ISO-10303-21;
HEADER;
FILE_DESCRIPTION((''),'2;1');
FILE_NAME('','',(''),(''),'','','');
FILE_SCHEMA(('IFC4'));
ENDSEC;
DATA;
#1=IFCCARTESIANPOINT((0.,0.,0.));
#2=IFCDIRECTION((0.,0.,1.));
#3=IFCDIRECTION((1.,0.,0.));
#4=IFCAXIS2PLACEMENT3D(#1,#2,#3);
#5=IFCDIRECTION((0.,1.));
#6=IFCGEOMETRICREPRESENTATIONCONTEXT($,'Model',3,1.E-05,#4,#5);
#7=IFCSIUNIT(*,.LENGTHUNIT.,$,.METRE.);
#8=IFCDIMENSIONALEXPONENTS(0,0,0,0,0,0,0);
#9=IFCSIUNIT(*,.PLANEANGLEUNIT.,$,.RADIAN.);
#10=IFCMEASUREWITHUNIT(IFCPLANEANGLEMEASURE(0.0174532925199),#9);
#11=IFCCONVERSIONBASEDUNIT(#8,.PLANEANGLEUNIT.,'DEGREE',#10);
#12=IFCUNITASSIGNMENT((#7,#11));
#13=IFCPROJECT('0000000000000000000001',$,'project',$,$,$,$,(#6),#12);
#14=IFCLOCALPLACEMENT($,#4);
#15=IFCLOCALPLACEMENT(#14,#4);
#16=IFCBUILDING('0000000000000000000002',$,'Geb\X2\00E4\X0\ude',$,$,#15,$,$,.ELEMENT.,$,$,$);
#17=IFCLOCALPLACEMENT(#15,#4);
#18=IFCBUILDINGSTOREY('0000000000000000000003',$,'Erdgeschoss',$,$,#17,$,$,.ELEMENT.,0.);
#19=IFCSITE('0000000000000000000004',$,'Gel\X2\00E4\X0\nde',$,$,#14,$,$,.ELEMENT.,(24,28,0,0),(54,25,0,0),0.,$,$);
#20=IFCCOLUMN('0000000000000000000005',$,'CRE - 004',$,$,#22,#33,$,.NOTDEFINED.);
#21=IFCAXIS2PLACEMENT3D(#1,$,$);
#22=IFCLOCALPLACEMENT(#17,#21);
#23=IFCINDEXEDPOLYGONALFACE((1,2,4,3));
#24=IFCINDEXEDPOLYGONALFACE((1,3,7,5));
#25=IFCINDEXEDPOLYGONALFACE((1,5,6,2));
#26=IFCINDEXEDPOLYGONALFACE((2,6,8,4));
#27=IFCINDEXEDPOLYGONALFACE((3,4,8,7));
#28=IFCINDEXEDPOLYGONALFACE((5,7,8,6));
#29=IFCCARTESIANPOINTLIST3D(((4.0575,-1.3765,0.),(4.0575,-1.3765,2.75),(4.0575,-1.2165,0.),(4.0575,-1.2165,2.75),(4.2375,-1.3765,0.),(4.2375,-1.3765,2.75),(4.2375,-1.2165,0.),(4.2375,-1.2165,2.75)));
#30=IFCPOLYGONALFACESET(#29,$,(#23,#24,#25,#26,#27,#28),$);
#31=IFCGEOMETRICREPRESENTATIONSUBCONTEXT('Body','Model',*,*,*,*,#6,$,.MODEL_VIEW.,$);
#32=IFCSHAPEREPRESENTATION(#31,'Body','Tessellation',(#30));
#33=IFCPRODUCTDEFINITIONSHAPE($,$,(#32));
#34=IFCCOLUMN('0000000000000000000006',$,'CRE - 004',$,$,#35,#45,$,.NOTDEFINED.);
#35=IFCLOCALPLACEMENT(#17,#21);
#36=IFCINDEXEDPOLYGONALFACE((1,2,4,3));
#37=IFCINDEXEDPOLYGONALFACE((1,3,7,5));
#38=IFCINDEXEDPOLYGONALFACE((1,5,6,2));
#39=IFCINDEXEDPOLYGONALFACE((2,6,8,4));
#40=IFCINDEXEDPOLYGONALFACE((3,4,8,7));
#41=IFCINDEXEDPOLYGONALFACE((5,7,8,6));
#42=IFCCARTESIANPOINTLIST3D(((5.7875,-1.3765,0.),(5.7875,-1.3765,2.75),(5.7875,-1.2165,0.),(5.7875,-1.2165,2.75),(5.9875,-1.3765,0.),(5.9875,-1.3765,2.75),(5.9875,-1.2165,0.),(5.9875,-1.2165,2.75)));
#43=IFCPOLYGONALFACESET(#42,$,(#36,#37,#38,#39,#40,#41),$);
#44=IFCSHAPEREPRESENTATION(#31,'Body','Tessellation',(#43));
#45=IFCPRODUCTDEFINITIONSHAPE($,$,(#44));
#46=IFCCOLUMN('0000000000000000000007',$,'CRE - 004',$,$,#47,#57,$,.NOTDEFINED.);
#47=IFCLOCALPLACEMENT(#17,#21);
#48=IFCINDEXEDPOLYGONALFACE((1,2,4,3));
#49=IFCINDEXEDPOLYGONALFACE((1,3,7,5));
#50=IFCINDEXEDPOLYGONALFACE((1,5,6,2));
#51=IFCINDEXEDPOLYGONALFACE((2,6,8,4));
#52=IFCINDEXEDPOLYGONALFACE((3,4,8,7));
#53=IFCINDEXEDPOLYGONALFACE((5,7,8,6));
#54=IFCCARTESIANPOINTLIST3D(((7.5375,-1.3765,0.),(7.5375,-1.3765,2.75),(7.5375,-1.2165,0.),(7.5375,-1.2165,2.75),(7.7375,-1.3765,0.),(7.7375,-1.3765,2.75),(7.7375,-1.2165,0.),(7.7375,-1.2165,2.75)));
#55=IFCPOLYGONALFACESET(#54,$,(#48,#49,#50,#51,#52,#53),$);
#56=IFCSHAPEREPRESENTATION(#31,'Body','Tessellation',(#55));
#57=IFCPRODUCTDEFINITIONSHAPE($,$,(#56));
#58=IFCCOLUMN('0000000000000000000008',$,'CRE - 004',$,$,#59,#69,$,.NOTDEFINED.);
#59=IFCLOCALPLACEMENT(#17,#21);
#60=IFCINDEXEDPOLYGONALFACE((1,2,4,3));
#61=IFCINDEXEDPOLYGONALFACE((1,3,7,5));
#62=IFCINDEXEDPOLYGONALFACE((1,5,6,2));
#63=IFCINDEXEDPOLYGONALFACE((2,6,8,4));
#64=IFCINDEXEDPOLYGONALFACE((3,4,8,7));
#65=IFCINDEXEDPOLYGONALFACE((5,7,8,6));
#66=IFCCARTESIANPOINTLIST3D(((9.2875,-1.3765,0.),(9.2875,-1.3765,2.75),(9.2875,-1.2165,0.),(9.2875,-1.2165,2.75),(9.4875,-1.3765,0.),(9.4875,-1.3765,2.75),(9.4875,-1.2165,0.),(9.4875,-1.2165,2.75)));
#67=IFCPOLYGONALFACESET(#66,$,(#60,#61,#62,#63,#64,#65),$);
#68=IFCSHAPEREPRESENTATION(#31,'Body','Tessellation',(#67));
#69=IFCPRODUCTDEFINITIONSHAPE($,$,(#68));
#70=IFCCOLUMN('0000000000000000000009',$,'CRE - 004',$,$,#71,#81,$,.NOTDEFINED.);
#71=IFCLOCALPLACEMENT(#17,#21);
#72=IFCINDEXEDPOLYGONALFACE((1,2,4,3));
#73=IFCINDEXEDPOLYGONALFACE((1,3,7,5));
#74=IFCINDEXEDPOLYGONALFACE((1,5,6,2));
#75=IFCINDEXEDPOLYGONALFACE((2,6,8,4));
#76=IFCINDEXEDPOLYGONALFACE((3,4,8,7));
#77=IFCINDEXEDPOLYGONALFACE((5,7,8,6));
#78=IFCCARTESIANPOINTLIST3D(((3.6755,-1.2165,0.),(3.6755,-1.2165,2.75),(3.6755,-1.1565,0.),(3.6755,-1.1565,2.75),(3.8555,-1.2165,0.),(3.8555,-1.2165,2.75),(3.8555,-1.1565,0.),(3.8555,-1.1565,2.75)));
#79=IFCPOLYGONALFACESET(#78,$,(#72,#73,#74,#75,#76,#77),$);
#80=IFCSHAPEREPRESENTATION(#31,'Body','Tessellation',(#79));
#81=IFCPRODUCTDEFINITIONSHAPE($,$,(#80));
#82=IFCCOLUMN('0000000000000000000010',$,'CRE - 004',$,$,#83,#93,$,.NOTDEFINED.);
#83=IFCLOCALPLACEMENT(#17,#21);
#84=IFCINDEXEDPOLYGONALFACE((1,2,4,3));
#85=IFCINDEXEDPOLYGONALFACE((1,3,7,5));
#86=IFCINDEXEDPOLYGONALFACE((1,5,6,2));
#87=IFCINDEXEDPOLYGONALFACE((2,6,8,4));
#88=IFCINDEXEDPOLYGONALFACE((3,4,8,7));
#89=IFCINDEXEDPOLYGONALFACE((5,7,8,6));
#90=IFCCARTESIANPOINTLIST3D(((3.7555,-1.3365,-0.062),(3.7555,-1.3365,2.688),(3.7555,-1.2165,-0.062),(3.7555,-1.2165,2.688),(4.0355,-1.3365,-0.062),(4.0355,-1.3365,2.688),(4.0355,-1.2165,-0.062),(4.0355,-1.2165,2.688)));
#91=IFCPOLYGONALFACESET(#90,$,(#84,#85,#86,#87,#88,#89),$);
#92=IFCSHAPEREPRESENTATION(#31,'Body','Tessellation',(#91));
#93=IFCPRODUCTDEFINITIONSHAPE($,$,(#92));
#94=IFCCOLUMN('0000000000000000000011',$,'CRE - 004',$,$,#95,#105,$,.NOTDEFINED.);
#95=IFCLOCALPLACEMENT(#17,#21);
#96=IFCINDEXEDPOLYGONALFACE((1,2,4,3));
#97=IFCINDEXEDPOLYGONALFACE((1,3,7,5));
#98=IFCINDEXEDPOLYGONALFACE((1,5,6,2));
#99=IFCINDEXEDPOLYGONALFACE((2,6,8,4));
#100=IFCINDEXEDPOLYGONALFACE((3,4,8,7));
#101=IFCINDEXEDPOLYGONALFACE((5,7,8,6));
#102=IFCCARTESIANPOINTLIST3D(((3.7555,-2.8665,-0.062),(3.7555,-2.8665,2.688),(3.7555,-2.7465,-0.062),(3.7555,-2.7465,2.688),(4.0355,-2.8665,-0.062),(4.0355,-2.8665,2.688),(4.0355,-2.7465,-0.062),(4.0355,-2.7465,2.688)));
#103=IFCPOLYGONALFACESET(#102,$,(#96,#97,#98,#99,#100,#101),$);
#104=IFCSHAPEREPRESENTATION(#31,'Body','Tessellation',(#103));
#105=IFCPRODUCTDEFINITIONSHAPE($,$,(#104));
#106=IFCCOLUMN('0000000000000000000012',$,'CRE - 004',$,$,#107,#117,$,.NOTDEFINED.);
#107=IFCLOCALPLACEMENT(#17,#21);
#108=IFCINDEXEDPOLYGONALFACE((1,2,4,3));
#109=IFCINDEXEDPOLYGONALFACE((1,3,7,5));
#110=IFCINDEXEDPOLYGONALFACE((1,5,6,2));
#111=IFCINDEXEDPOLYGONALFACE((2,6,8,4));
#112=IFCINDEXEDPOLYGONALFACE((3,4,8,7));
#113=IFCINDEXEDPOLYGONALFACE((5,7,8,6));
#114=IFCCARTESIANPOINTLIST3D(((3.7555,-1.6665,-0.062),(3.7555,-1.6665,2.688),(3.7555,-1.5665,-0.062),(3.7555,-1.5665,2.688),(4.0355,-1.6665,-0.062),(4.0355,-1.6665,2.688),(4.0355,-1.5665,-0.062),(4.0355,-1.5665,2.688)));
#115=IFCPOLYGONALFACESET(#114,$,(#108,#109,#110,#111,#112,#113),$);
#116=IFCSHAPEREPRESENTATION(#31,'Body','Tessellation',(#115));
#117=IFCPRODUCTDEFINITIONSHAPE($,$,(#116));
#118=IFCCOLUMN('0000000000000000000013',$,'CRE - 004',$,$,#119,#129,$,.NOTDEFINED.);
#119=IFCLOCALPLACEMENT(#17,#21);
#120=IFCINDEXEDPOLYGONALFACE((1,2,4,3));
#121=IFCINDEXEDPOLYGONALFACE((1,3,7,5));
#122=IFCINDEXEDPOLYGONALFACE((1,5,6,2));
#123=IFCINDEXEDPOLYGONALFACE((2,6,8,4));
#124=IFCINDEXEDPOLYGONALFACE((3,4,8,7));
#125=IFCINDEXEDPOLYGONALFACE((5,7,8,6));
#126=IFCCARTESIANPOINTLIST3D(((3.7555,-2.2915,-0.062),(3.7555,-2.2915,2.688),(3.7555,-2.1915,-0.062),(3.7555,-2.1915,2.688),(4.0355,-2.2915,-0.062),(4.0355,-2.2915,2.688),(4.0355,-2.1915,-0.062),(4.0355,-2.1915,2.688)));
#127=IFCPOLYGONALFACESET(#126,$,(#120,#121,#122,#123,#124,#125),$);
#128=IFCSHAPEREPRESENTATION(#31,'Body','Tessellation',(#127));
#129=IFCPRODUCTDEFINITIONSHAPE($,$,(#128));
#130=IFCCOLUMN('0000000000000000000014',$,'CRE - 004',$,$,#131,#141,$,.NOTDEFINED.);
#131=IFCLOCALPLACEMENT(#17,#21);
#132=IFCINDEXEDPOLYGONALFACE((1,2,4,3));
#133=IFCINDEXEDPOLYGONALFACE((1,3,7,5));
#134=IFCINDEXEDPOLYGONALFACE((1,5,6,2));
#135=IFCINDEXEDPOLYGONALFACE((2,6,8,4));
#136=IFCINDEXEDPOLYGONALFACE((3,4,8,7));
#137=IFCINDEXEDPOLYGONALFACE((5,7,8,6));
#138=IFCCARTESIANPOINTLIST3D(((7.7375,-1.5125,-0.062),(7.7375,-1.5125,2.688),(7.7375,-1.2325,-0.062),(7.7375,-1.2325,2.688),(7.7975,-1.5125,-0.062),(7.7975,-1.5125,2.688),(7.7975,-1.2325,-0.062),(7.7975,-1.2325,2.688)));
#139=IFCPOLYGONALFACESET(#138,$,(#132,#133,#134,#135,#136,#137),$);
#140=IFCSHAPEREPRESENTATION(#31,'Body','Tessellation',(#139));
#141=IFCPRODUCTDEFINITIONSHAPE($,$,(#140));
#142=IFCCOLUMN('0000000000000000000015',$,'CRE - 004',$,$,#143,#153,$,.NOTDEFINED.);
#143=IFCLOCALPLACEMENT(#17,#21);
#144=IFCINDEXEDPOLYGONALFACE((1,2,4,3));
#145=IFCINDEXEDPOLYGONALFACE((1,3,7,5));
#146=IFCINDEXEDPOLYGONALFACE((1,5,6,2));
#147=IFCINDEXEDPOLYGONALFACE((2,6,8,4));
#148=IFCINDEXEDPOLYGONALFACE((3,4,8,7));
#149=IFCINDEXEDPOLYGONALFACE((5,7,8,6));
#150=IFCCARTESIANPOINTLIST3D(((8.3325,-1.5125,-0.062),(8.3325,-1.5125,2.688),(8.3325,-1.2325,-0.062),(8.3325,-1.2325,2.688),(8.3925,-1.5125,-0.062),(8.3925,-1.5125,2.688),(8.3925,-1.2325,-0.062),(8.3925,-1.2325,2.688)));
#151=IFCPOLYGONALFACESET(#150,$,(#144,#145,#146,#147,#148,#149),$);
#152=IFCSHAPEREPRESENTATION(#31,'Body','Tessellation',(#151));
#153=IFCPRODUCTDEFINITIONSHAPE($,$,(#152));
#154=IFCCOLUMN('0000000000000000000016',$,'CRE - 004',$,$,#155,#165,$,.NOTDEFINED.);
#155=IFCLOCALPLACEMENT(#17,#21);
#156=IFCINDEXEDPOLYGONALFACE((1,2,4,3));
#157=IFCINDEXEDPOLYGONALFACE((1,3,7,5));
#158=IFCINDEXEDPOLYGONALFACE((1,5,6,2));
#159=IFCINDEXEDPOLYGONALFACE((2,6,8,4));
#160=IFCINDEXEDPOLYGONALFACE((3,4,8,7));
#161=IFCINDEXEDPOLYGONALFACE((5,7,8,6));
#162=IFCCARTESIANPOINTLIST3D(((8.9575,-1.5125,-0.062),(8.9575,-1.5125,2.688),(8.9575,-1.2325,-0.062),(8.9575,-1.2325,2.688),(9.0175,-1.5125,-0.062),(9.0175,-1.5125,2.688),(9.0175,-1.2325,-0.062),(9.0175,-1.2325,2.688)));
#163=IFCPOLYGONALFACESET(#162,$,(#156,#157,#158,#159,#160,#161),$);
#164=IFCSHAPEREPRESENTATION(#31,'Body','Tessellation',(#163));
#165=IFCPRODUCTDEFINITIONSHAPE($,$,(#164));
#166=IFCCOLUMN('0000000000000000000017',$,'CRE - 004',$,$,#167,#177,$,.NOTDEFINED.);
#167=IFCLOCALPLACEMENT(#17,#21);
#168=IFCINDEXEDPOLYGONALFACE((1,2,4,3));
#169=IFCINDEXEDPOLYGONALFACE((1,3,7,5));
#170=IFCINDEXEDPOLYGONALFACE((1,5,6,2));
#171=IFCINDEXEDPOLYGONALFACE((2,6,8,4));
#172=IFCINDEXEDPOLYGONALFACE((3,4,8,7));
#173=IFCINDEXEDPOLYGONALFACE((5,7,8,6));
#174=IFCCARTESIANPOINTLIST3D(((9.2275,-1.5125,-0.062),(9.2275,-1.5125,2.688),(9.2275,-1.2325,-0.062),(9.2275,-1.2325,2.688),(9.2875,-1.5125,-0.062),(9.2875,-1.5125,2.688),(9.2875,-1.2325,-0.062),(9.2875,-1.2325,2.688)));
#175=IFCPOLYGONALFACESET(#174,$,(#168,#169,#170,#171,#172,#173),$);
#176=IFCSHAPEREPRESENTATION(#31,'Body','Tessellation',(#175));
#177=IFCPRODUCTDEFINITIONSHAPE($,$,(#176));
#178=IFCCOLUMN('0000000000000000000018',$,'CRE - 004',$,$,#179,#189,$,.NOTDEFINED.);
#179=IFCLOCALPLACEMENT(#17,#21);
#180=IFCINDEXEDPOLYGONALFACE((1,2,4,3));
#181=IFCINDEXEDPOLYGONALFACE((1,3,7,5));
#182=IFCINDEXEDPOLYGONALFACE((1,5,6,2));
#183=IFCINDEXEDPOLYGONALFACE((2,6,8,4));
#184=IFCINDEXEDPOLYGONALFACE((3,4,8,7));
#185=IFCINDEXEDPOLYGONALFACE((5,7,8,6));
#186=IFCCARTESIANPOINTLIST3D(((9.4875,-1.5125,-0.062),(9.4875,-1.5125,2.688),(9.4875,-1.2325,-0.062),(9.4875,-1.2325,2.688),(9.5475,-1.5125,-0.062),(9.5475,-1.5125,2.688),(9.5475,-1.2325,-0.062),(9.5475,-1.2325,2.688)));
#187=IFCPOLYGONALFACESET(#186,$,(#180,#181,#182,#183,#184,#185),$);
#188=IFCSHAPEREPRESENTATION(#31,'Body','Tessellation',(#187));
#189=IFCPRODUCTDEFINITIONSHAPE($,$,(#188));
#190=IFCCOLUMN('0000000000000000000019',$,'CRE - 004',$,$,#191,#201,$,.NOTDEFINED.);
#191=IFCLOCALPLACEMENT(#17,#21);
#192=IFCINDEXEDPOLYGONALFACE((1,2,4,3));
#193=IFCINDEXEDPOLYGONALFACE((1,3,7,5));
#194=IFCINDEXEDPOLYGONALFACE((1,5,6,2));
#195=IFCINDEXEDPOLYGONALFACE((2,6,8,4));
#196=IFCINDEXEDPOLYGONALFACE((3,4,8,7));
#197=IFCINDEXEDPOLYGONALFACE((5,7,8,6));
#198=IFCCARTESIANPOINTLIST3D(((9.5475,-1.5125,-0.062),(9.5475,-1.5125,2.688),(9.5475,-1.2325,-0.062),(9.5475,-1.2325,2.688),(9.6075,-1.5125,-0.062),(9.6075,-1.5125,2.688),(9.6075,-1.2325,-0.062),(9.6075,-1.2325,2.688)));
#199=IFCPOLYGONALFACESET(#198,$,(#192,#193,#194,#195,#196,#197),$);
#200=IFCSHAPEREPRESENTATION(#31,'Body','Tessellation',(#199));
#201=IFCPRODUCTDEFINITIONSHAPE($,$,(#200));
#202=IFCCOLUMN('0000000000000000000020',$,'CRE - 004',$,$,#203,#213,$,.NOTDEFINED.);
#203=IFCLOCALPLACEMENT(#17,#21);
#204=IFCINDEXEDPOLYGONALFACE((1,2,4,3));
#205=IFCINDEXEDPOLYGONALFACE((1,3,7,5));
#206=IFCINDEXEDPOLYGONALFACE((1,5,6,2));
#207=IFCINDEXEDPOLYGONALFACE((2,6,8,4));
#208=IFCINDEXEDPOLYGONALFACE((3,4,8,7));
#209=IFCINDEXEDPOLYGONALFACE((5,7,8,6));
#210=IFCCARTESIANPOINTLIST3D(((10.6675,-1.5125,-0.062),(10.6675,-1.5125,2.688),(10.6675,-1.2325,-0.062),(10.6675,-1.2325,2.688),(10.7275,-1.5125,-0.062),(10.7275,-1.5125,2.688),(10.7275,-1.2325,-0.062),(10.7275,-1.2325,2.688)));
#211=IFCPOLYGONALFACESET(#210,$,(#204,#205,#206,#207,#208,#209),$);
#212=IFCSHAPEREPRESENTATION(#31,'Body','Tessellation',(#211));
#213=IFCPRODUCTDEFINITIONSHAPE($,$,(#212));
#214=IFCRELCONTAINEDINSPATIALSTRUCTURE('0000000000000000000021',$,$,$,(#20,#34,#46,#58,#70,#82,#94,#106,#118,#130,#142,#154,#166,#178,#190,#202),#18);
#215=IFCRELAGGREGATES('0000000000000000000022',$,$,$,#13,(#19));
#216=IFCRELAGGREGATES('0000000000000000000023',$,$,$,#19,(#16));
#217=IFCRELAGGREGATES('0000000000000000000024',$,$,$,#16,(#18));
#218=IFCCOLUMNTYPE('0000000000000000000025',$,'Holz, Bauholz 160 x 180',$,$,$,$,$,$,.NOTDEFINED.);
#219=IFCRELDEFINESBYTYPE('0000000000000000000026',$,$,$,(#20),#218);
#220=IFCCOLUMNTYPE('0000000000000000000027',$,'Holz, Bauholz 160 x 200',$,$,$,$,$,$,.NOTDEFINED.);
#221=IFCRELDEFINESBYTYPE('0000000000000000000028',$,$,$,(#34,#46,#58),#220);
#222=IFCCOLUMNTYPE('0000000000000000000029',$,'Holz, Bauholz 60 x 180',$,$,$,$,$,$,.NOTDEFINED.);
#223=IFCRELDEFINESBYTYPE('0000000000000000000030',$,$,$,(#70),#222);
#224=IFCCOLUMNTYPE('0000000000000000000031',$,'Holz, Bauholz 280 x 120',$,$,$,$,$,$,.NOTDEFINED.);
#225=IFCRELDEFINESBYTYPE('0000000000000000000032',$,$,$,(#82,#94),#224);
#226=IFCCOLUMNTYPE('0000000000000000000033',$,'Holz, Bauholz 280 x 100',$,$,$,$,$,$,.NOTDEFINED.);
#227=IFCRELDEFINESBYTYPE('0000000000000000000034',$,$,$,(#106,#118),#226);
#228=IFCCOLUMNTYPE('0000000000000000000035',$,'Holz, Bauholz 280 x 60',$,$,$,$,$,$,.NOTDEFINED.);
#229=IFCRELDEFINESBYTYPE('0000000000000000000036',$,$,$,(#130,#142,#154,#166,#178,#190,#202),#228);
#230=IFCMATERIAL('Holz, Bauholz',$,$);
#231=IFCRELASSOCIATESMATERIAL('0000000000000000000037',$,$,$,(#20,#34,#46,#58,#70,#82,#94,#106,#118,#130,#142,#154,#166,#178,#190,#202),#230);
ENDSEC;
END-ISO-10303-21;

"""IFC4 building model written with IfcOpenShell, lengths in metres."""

from ifc_helpers import new_model, entity, si_unit, converted_unit, direction, frame, origin_with_axes, origin_2d_with_axis, place, context, subcontext, project, spatial, rectangle, extrude, material, type_object, element, save


model = new_model("IFC4")

# Units and contexts
model_context = context("Model", 3, precision=1e-05, world=origin_with_axes(), true_north=direction((0.0, 1.0)))
body_context = subcontext(model_context, "Body", "Model", "MODEL_VIEW")
ifc_project = project(units=[si_unit("LENGTHUNIT", "METRE"), converted_unit("PLANEANGLEUNIT", "DEGREE", entity("IfcPlaneAngleMeasure", 0.0174532925199), si_unit("PLANEANGLEUNIT", "RADIAN"), dimensions=[0, 0, 0, 0, 0, 0, 0])], contexts=[model_context])

# Site, building, storey
site_placement = place(None, origin_with_axes())
site = spatial("IfcSite", under=ifc_project, at=site_placement, Name="Gelände", CompositionType="ELEMENT", RefLatitude=(24, 28, 0, 0), RefLongitude=(54, 25, 0, 0), RefElevation=0.0)
building_placement = place(site_placement, origin_with_axes())
building = spatial("IfcBuilding", under=site, at=building_placement, Name="Gebäude", CompositionType="ELEMENT")
storey_placement = place(building_placement, origin_with_axes())
storey = spatial("IfcBuildingStorey", under=building, at=storey_placement, Name="Erdgeschoss", CompositionType="ELEMENT", Elevation=0.0)

# Columns
ifc_material_1 = material(Name="Holz, Bauholz")
column_type_1 = type_object("IfcColumnType", Name="Holz, Bauholz 160 x 180", PredefinedType="NOTDEFINED")
column_1_placement = place(storey_placement, frame((4.1475, -1.2965, 0.0), z_axis=(0.0, 0.0, 1.0), x_axis=(1.0, 0.0, 0.0)))
element("IfcColumn", 1, at=column_1_placement, inside=storey, type_object=column_type_1, material=ifc_material_1, Name="CRE - 004", PredefinedType="NOTDEFINED", context=body_context, shape_type="SweptSolid", body=[
    extrude(rectangle(XDim=0.16, YDim=0.18, at=origin_2d_with_axis()), frame((0.0, 0.0, 0.0), z_axis=(0.0, 0.0, 1.0), x_axis=(0.0, 1.0, 0.0)), (0.0, 0.0, 1.0), 2.75),
])
column_type_2 = type_object("IfcColumnType", Name="Holz, Bauholz 160 x 200", PredefinedType="NOTDEFINED")
for number, where, z_axis, x_axis, name in (
    (2, (5.8875, -1.2965, 0.0), (0.0, 0.0, 1.0), (1.0, 0.0, 0.0), "CRE - 004"),
    (3, (7.6375, -1.2965, 0.0), (0.0, 0.0, 1.0), (1.0, 0.0, 0.0), "CRE - 004"),
    (4, (9.3875, -1.2965, 0.0), (0.0, 0.0, 1.0), (1.0, 0.0, 0.0), "CRE - 004"),
):
    element("IfcColumn", number, at=place(storey_placement, frame(where, z_axis=z_axis, x_axis=x_axis)), inside=storey, type_object=column_type_2, material=ifc_material_1, Name=name, PredefinedType="NOTDEFINED", context=body_context, shape_type="SweptSolid", body=[
        extrude(rectangle(XDim=0.16, YDim=0.2, at=origin_2d_with_axis()), frame((0.0, 0.0, 0.0), z_axis=(0.0, 0.0, 1.0), x_axis=(0.0, 1.0, 0.0)), (0.0, 0.0, 1.0), 2.75),
    ])
column_type_3 = type_object("IfcColumnType", Name="Holz, Bauholz 60 x 180", PredefinedType="NOTDEFINED")
column_2_placement = place(storey_placement, frame((3.7655, -1.1865, 0.0), z_axis=(0.0, 0.0, 1.0), x_axis=(1.0, 0.0, 0.0)))
element("IfcColumn", 5, at=column_2_placement, inside=storey, type_object=column_type_3, material=ifc_material_1, Name="CRE - 004", PredefinedType="NOTDEFINED", context=body_context, shape_type="SweptSolid", body=[
    extrude(rectangle(XDim=0.06, YDim=0.18, at=origin_2d_with_axis()), frame((0.0, 0.0, 0.0), z_axis=(0.0, 0.0, 1.0), x_axis=(0.0, 1.0, 0.0)), (0.0, 0.0, 1.0), 2.75),
])
column_type_4 = type_object("IfcColumnType", Name="Holz, Bauholz 280 x 120", PredefinedType="NOTDEFINED")
for number, where, z_axis, x_axis, name in (
    (6, (3.8955, -1.2765, -0.062), (0.0, 0.0, 1.0), (0.0, 1.0, 0.0), "CRE - 004"),
    (7, (3.8955, -2.8065, -0.062), (0.0, 0.0, 1.0), (0.0, 1.0, 0.0), "CRE - 004"),
):
    element("IfcColumn", number, at=place(storey_placement, frame(where, z_axis=z_axis, x_axis=x_axis)), inside=storey, type_object=column_type_4, material=ifc_material_1, Name=name, PredefinedType="NOTDEFINED", context=body_context, shape_type="SweptSolid", body=[
        extrude(rectangle(XDim=0.28, YDim=0.12, at=origin_2d_with_axis()), frame((0.0, 0.0, 0.0), z_axis=(0.0, 0.0, 1.0), x_axis=(0.0, 1.0, 0.0)), (0.0, 0.0, 1.0), 2.75),
    ])
column_type_5 = type_object("IfcColumnType", Name="Holz, Bauholz 280 x 100", PredefinedType="NOTDEFINED")
for number, where, z_axis, x_axis, name in (
    (8, (3.8955, -1.6165, -0.062), (0.0, 0.0, 1.0), (0.0, 1.0, 0.0), "CRE - 004"),
    (9, (3.8955, -2.2415, -0.062), (0.0, 0.0, 1.0), (0.0, 1.0, 0.0), "CRE - 004"),
):
    element("IfcColumn", number, at=place(storey_placement, frame(where, z_axis=z_axis, x_axis=x_axis)), inside=storey, type_object=column_type_5, material=ifc_material_1, Name=name, PredefinedType="NOTDEFINED", context=body_context, shape_type="SweptSolid", body=[
        extrude(rectangle(XDim=0.28, YDim=0.1, at=origin_2d_with_axis()), frame((0.0, 0.0, 0.0), z_axis=(0.0, 0.0, 1.0), x_axis=(0.0, 1.0, 0.0)), (0.0, 0.0, 1.0), 2.75),
    ])
column_type_6 = type_object("IfcColumnType", Name="Holz, Bauholz 280 x 60", PredefinedType="NOTDEFINED")
for number, where, z_axis, x_axis, name in (
    (10, (7.7675, -1.3725, -0.062), (0.0, 0.0, 1.0), (-1.0, 0.0, 0.0), "CRE - 004"),
    (11, (8.3625, -1.3725, -0.062), (0.0, 0.0, 1.0), (-1.0, 0.0, 0.0), "CRE - 004"),
    (12, (8.9875, -1.3725, -0.062), (0.0, 0.0, 1.0), (-1.0, 0.0, 0.0), "CRE - 004"),
    (13, (9.2575, -1.3725, -0.062), (0.0, 0.0, 1.0), (-1.0, 0.0, 0.0), "CRE - 004"),
    (14, (9.5175, -1.3725, -0.062), (0.0, 0.0, 1.0), (-1.0, 0.0, 0.0), "CRE - 004"),
    (15, (9.5775, -1.3725, -0.062), (0.0, 0.0, 1.0), (-1.0, 0.0, 0.0), "CRE - 004"),
    (16, (10.6975, -1.3725, -0.062), (0.0, 0.0, 1.0), (-1.0, 0.0, 0.0), "CRE - 004"),
):
    element("IfcColumn", number, at=place(storey_placement, frame(where, z_axis=z_axis, x_axis=x_axis)), inside=storey, type_object=column_type_6, material=ifc_material_1, Name=name, PredefinedType="NOTDEFINED", context=body_context, shape_type="SweptSolid", body=[
        extrude(rectangle(XDim=0.28, YDim=0.06, at=origin_2d_with_axis()), frame((0.0, 0.0, 0.0), z_axis=(0.0, 0.0, 1.0), x_axis=(0.0, 1.0, 0.0)), (0.0, 0.0, 1.0), 2.75),
    ])

save(model, "model.ifc")
